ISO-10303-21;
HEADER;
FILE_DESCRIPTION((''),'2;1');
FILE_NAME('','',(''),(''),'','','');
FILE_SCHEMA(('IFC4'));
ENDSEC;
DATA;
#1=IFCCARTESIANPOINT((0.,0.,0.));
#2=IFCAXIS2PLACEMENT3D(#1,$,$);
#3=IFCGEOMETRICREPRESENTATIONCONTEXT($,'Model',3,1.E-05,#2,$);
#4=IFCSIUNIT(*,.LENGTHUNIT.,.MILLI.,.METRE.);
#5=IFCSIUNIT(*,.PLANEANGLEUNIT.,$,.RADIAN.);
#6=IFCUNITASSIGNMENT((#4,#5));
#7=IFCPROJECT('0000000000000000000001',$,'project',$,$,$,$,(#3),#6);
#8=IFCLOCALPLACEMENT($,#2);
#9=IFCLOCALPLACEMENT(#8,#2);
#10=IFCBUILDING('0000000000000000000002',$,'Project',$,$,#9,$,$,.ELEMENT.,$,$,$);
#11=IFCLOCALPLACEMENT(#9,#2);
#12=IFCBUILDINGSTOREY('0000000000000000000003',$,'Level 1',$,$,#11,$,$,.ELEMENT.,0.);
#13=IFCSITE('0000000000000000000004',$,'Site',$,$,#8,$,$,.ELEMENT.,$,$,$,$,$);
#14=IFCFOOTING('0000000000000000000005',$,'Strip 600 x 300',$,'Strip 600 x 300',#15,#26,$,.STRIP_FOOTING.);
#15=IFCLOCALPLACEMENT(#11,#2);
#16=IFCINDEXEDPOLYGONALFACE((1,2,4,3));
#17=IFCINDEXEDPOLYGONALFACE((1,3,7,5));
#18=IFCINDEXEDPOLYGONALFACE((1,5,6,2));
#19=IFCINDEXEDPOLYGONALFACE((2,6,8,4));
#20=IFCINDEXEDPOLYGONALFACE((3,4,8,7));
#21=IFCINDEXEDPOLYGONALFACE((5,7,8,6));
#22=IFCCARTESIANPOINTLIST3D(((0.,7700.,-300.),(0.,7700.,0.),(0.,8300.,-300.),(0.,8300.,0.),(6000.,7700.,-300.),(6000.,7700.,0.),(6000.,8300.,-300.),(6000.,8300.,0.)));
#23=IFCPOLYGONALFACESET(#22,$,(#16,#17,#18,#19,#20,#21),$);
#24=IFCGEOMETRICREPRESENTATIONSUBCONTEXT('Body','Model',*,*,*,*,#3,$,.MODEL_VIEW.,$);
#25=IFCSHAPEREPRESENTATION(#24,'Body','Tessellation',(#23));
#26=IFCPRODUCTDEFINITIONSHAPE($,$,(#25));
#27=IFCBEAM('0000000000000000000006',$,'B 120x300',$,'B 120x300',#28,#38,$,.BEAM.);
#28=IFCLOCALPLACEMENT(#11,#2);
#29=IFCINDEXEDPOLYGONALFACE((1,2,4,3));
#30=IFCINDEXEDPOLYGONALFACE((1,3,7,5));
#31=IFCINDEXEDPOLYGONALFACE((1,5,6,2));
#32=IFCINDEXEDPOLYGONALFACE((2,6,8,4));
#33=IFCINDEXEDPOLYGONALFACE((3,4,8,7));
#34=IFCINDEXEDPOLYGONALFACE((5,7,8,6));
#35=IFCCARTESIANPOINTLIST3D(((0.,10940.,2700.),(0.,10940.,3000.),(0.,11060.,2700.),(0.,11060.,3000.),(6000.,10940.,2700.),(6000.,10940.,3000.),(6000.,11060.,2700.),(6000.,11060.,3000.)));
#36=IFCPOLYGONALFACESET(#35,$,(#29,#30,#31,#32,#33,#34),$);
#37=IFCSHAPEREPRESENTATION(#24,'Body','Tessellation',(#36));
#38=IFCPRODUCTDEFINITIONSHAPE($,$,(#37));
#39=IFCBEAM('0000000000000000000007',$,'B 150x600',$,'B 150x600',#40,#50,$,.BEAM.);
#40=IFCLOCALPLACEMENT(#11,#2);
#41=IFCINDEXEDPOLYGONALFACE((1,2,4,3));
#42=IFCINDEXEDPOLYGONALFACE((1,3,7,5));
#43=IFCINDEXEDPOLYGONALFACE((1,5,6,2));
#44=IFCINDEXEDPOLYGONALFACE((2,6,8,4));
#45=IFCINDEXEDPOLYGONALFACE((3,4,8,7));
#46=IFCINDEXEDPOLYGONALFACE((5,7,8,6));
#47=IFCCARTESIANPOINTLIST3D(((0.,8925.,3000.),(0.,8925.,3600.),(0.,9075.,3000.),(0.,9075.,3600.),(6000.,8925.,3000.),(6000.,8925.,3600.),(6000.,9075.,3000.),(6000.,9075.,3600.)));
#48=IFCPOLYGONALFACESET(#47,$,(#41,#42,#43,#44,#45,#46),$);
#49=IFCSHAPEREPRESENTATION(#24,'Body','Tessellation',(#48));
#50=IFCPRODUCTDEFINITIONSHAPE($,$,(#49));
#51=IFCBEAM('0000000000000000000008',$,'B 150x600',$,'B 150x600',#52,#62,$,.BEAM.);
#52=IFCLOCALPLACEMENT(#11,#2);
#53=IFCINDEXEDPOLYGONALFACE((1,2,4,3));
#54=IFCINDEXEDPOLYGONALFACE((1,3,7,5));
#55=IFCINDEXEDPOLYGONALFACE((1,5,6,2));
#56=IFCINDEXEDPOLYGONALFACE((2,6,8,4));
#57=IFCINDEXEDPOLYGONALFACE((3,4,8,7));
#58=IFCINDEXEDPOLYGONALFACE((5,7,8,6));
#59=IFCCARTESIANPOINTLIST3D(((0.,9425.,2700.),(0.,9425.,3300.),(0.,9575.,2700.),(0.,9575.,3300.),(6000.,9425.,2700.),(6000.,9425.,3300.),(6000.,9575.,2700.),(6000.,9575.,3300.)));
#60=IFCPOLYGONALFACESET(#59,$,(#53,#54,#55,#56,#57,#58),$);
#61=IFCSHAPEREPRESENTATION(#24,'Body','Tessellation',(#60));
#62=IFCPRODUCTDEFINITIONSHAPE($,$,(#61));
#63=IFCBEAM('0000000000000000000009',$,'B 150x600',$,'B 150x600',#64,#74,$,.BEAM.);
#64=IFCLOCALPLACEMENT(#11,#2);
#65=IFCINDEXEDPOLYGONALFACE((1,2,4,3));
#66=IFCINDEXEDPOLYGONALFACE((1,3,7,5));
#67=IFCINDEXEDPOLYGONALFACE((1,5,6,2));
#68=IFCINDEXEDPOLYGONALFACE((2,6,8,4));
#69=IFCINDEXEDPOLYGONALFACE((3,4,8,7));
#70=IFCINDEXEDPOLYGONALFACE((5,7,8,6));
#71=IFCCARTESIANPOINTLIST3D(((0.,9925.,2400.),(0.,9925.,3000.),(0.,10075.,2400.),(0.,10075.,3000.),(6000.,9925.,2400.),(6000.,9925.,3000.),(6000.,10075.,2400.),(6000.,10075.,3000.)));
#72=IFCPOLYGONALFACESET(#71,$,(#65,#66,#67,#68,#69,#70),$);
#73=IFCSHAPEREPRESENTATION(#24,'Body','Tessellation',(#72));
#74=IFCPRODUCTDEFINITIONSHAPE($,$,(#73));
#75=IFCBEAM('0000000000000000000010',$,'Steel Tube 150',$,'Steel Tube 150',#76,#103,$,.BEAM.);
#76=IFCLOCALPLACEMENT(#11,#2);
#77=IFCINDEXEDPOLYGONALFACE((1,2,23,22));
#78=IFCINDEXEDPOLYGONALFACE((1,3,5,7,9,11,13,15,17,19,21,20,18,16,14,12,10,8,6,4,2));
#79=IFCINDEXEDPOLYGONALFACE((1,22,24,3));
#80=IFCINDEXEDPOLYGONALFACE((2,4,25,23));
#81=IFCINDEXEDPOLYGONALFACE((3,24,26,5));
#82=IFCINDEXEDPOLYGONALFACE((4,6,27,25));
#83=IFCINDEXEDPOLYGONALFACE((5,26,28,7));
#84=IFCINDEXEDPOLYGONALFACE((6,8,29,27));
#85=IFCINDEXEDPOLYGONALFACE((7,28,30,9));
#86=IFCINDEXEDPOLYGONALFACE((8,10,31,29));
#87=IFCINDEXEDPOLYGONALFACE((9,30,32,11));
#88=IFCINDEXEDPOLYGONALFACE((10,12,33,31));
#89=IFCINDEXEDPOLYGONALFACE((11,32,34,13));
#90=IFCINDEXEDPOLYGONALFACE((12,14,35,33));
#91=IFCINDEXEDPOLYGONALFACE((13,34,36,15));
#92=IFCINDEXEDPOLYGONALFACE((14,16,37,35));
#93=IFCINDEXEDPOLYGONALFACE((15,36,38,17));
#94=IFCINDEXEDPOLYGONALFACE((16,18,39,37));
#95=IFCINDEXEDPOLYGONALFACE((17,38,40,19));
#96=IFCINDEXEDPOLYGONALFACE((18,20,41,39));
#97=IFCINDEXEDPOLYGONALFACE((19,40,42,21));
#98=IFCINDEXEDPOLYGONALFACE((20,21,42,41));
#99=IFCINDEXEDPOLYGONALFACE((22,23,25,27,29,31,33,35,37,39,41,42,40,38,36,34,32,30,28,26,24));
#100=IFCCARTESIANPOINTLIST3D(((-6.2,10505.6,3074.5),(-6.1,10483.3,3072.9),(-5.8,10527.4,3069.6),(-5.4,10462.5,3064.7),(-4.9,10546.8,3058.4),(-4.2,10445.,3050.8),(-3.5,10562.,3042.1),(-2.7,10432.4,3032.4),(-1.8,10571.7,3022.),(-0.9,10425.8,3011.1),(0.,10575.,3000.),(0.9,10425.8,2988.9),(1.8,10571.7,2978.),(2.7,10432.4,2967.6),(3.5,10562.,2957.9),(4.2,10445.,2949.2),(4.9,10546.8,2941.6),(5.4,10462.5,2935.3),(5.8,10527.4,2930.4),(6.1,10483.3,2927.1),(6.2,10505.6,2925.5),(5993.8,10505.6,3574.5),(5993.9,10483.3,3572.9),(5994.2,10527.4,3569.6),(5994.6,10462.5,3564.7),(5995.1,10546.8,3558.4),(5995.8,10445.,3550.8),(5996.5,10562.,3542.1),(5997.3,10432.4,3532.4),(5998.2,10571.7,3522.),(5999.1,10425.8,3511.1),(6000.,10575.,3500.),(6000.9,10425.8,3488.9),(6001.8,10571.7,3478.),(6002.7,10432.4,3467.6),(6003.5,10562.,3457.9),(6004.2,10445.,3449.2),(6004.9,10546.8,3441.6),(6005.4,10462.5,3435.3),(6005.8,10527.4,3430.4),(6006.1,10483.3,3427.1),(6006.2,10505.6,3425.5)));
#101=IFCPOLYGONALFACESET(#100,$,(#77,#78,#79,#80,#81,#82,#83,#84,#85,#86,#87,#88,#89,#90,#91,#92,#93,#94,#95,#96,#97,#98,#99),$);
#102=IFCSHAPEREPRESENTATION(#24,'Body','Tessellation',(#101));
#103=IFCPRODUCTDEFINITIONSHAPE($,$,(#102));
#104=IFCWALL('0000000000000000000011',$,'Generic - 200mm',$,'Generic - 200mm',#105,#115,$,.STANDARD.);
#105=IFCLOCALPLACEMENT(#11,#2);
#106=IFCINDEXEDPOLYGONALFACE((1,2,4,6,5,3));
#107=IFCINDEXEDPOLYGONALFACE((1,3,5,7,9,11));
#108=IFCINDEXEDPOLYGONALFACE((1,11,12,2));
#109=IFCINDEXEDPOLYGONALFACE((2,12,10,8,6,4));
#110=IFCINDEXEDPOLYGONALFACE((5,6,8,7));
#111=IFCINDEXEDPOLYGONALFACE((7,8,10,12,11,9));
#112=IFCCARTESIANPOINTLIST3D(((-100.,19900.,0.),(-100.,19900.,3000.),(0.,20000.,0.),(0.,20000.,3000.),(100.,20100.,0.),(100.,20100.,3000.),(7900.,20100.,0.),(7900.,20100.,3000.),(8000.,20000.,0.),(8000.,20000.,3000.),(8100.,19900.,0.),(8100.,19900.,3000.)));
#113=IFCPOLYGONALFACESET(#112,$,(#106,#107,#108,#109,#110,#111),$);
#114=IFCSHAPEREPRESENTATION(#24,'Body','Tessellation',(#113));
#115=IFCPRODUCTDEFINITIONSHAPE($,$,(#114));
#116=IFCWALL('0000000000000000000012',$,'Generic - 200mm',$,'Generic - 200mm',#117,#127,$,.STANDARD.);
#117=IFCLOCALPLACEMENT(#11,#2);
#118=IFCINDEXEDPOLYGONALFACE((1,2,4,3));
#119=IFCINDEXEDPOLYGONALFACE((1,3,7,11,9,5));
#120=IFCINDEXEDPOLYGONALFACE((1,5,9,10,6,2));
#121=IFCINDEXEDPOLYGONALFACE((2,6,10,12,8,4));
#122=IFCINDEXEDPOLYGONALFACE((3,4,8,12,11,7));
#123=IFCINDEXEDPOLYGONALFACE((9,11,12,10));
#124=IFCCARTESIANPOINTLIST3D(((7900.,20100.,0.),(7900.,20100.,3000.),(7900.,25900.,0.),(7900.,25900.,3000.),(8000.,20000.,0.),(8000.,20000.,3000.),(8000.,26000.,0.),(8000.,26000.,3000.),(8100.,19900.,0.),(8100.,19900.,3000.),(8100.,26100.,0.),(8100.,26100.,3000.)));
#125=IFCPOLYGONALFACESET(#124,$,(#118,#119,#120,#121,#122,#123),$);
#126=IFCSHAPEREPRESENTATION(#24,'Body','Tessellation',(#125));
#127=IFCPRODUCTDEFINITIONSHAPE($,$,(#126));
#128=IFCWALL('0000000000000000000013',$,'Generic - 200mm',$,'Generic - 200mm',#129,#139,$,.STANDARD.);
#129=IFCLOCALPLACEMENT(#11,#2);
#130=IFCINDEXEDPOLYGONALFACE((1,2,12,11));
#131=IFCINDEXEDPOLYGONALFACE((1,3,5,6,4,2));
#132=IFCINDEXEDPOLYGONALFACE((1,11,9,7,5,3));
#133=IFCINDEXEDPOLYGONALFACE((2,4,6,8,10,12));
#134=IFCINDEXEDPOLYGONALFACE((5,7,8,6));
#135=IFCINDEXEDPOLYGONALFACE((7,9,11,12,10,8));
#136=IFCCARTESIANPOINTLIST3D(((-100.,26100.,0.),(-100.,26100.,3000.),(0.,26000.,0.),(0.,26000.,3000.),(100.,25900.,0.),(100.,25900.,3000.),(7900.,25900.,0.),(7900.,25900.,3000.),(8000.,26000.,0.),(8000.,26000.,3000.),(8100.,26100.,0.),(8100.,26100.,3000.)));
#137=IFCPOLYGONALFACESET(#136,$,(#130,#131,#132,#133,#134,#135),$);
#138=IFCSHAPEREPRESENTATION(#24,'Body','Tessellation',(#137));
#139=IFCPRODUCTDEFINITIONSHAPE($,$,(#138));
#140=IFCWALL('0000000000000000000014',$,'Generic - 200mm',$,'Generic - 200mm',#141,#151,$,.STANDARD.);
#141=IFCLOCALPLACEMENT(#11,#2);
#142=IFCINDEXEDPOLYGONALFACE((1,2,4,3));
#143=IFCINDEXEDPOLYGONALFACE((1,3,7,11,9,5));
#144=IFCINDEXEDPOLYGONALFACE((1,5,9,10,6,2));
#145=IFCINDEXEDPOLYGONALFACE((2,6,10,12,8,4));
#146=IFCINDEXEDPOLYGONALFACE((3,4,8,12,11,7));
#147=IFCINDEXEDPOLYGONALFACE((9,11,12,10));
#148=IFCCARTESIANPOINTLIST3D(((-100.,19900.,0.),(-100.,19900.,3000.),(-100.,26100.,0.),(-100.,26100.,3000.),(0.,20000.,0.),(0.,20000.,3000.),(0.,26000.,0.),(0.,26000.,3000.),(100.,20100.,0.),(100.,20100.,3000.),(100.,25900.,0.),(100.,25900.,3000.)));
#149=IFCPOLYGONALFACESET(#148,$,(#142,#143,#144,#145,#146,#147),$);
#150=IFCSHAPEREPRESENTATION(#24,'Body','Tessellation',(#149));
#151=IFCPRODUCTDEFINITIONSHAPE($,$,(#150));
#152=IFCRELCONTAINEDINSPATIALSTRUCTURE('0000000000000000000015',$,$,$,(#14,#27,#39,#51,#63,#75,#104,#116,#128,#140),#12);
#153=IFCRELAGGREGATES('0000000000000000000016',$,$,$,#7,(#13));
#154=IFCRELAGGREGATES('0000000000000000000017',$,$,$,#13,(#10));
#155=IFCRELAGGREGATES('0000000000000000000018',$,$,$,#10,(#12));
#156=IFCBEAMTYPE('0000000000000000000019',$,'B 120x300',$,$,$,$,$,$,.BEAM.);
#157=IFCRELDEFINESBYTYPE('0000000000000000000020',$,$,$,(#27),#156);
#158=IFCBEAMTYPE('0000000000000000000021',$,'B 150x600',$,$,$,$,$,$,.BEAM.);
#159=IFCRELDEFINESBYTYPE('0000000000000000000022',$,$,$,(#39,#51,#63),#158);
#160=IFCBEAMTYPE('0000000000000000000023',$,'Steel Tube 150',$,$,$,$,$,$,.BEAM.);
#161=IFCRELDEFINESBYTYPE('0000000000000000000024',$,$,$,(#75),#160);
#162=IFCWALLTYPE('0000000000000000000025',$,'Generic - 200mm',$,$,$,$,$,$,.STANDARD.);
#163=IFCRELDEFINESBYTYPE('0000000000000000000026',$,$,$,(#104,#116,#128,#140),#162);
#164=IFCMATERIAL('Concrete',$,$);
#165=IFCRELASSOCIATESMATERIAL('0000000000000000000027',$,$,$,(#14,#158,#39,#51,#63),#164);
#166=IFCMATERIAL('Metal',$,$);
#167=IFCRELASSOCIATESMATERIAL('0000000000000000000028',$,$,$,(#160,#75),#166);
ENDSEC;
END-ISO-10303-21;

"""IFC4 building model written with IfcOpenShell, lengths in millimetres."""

from ifc_helpers import new_model, si_unit, frame, origin, origin_2d, place, context, subcontext, project, spatial, polyline, rectangle, circle, outline, extrude, material, material_profile, profile_set, profile_usage, type_object, element, save


model = new_model("IFC4")

# Units and contexts
model_context = context("Model", 3, precision=1e-05, world=origin())
body_context = subcontext(model_context, "Body", "Model", "MODEL_VIEW")
ifc_project = project(units=[si_unit("LENGTHUNIT", "METRE", prefix="MILLI"), si_unit("PLANEANGLEUNIT", "RADIAN")], contexts=[model_context])

# Site, building, storey
site_placement = place(None, origin())
site = spatial("IfcSite", under=ifc_project, at=site_placement, Name="Site", CompositionType="ELEMENT")
building_placement = place(site_placement, origin())
building = spatial("IfcBuilding", under=site, at=building_placement, Name="Project", CompositionType="ELEMENT")
storey_placement = place(building_placement, origin())
storey = spatial("IfcBuildingStorey", under=building, at=storey_placement, Name="Level 1", CompositionType="ELEMENT", Elevation=0.0)

# Footing
ifc_material_1 = material(Name="Concrete")
footing_placement = place(storey_placement, frame((0.0, 8000.0, -150.0)))
element("IfcFooting", 1, at=footing_placement, inside=storey, material=ifc_material_1, Name="Strip 600 x 300", ObjectType="Strip 600 x 300", PredefinedType="STRIP_FOOTING", context=body_context, shape_type="SweptSolid", body=[
    extrude(rectangle(XDim=600.0, YDim=300.0, at=origin_2d()), frame((0.0, 0.0, 0.0), z_axis=(1.0, 0.0, 0.0), x_axis=(0.0, 1.0, 0.0)), (0.0, 0.0, 1.0), 6000.0),
])

# Beams
ifc_material_profile_1 = material_profile(None, rectangle(XDim=120.0, YDim=300.0, at=origin_2d()), Name="B 120x300")
ifc_profile_set_1 = profile_set([ifc_material_profile_1], Name="B 120x300")
ifc_profile_usage_1 = profile_usage(ifc_profile_set_1, cardinal=8)
beam_type_1 = type_object("IfcBeamType", Name="B 120x300", PredefinedType="BEAM", material=ifc_profile_set_1)
beam_1_placement = place(storey_placement, frame((0.0, 11000.0, 2850.0)))
element("IfcBeam", 2, at=beam_1_placement, inside=storey, type_object=beam_type_1, material=ifc_profile_usage_1, Name="B 120x300", ObjectType="B 120x300", PredefinedType="BEAM", context=body_context, shape_type="SweptSolid", body=[
    extrude(rectangle(XDim=120.0, YDim=300.0, at=origin_2d()), frame((0.0, 0.0, 0.0), z_axis=(1.0, 0.0, 0.0), x_axis=(0.0, 1.0, 0.0)), (0.0, 0.0, 1.0), 6000.0),
])
ifc_material_profile_2 = material_profile(ifc_material_1, rectangle(XDim=150.0, YDim=600.0, at=origin_2d()), Name="B 150x600")
ifc_profile_set_2 = profile_set([ifc_material_profile_2], Name="B 150x600")
ifc_profile_usage_2 = profile_usage(ifc_profile_set_2, cardinal=2)
beam_type_2 = type_object("IfcBeamType", Name="B 150x600", PredefinedType="BEAM", material=ifc_profile_set_2)
beam_2_placement = place(storey_placement, frame((0.0, 9000.0, 3300.0)))
element("IfcBeam", 3, at=beam_2_placement, inside=storey, type_object=beam_type_2, material=ifc_profile_usage_2, Name="B 150x600", ObjectType="B 150x600", PredefinedType="BEAM", context=body_context, shape_type="SweptSolid", body=[
    extrude(rectangle(XDim=150.0, YDim=600.0, at=origin_2d()), frame((0.0, 0.0, 0.0), z_axis=(1.0, 0.0, 0.0), x_axis=(0.0, 1.0, 0.0)), (0.0, 0.0, 1.0), 6000.0),
])
ifc_profile_usage_3 = profile_usage(ifc_profile_set_2, cardinal=5)
beam_3_placement = place(storey_placement, frame((0.0, 9500.0, 3000.0)))
element("IfcBeam", 4, at=beam_3_placement, inside=storey, type_object=beam_type_2, material=ifc_profile_usage_3, Name="B 150x600", ObjectType="B 150x600", PredefinedType="BEAM", context=body_context, shape_type="SweptSolid", body=[
    extrude(rectangle(XDim=150.0, YDim=600.0, at=origin_2d()), frame((0.0, 0.0, 0.0), z_axis=(1.0, 0.0, 0.0), x_axis=(0.0, 1.0, 0.0)), (0.0, 0.0, 1.0), 6000.0),
])
ifc_profile_usage_4 = profile_usage(ifc_profile_set_2, cardinal=8)
beam_4_placement = place(storey_placement, frame((0.0, 10000.0, 2700.0)))
element("IfcBeam", 5, at=beam_4_placement, inside=storey, type_object=beam_type_2, material=ifc_profile_usage_4, Name="B 150x600", ObjectType="B 150x600", PredefinedType="BEAM", context=body_context, shape_type="SweptSolid", body=[
    extrude(rectangle(XDim=150.0, YDim=600.0, at=origin_2d()), frame((0.0, 0.0, 0.0), z_axis=(1.0, 0.0, 0.0), x_axis=(0.0, 1.0, 0.0)), (0.0, 0.0, 1.0), 6000.0),
])
ifc_material_2 = material(Name="Metal")
ifc_material_profile_3 = material_profile(ifc_material_2, circle(Radius=75.0, at=origin_2d()), Name="Steel Tube 150")
ifc_profile_set_3 = profile_set([ifc_material_profile_3], Name="Steel Tube 150")
ifc_profile_usage_5 = profile_usage(ifc_profile_set_3, cardinal=5)
beam_type_3 = type_object("IfcBeamType", Name="Steel Tube 150", PredefinedType="BEAM", material=ifc_profile_set_3)
beam_5_placement = place(storey_placement, frame((0.0, 10500.0, 3000.0)))
element("IfcBeam", 6, at=beam_5_placement, inside=storey, type_object=beam_type_3, material=ifc_profile_usage_5, Name="Steel Tube 150", ObjectType="Steel Tube 150", PredefinedType="BEAM", context=body_context, shape_type="SweptSolid", body=[
    extrude(circle(Radius=75.0, at=origin_2d()), frame((0.0, 0.0, 0.0), z_axis=(0.996546, 0.0, 0.083045), x_axis=(0.0, 1.0, 0.0)), (0.0, 0.0, 1.0), 6020.8),
])

# Walls
wall_type = type_object("IfcWallType", Name="Generic - 200mm", PredefinedType="STANDARD")
wall_1_placement = place(storey_placement, frame((0.0, 20000.0, 0.0), z_axis=(0.0, 0.0, 1.0), x_axis=(1.0, 0.0, 0.0)))
element("IfcWall", 7, at=wall_1_placement, inside=storey, type_object=wall_type, Name="Generic - 200mm", ObjectType="Generic - 200mm", PredefinedType="STANDARD", context=body_context, shape_type="SweptSolid", body=[
    extrude(outline(polyline([(-100.0, -100.0), (0.0, 0.0), (100.0, 100.0), (7900.0, 100.0), (8000.0, 0.0), (8100.0, -100.0), (-100.0, -100.0)])), origin(), (0.0, 0.0, 1.0), 3000.0),
])
wall_2_placement = place(storey_placement, frame((8000.0, 20000.0, 0.0), z_axis=(0.0, 0.0, 1.0), x_axis=(0.0, 1.0, 0.0)))
element("IfcWall", 8, at=wall_2_placement, inside=storey, type_object=wall_type, Name="Generic - 200mm", ObjectType="Generic - 200mm", PredefinedType="STANDARD", context=body_context, shape_type="SweptSolid", body=[
    extrude(outline(polyline([(-100.0, -100.0), (0.0, 0.0), (100.0, 100.0), (5900.0, 100.0), (6000.0, 0.0), (6100.0, -100.0), (-100.0, -100.0)])), origin(), (0.0, 0.0, 1.0), 3000.0),
])
wall_3_placement = place(storey_placement, frame((8000.0, 26000.0, 0.0), z_axis=(0.0, 0.0, 1.0), x_axis=(-1.0, 0.0, 0.0)))
element("IfcWall", 9, at=wall_3_placement, inside=storey, type_object=wall_type, Name="Generic - 200mm", ObjectType="Generic - 200mm", PredefinedType="STANDARD", context=body_context, shape_type="SweptSolid", body=[
    extrude(outline(polyline([(-100.0, -100.0), (0.0, 0.0), (100.0, 100.0), (7900.0, 100.0), (8000.0, 0.0), (8100.0, -100.0), (-100.0, -100.0)])), origin(), (0.0, 0.0, 1.0), 3000.0),
])
wall_4_placement = place(storey_placement, frame((0.0, 26000.0, 0.0), z_axis=(0.0, 0.0, 1.0), x_axis=(0.0, -1.0, 0.0)))
element("IfcWall", 10, at=wall_4_placement, inside=storey, type_object=wall_type, Name="Generic - 200mm", ObjectType="Generic - 200mm", PredefinedType="STANDARD", context=body_context, shape_type="SweptSolid", body=[
    extrude(outline(polyline([(-100.0, -100.0), (0.0, 0.0), (100.0, 100.0), (5900.0, 100.0), (6000.0, 0.0), (6100.0, -100.0), (-100.0, -100.0)])), origin(), (0.0, 0.0, 1.0), 3000.0),
])

save(model, "model.ifc")
